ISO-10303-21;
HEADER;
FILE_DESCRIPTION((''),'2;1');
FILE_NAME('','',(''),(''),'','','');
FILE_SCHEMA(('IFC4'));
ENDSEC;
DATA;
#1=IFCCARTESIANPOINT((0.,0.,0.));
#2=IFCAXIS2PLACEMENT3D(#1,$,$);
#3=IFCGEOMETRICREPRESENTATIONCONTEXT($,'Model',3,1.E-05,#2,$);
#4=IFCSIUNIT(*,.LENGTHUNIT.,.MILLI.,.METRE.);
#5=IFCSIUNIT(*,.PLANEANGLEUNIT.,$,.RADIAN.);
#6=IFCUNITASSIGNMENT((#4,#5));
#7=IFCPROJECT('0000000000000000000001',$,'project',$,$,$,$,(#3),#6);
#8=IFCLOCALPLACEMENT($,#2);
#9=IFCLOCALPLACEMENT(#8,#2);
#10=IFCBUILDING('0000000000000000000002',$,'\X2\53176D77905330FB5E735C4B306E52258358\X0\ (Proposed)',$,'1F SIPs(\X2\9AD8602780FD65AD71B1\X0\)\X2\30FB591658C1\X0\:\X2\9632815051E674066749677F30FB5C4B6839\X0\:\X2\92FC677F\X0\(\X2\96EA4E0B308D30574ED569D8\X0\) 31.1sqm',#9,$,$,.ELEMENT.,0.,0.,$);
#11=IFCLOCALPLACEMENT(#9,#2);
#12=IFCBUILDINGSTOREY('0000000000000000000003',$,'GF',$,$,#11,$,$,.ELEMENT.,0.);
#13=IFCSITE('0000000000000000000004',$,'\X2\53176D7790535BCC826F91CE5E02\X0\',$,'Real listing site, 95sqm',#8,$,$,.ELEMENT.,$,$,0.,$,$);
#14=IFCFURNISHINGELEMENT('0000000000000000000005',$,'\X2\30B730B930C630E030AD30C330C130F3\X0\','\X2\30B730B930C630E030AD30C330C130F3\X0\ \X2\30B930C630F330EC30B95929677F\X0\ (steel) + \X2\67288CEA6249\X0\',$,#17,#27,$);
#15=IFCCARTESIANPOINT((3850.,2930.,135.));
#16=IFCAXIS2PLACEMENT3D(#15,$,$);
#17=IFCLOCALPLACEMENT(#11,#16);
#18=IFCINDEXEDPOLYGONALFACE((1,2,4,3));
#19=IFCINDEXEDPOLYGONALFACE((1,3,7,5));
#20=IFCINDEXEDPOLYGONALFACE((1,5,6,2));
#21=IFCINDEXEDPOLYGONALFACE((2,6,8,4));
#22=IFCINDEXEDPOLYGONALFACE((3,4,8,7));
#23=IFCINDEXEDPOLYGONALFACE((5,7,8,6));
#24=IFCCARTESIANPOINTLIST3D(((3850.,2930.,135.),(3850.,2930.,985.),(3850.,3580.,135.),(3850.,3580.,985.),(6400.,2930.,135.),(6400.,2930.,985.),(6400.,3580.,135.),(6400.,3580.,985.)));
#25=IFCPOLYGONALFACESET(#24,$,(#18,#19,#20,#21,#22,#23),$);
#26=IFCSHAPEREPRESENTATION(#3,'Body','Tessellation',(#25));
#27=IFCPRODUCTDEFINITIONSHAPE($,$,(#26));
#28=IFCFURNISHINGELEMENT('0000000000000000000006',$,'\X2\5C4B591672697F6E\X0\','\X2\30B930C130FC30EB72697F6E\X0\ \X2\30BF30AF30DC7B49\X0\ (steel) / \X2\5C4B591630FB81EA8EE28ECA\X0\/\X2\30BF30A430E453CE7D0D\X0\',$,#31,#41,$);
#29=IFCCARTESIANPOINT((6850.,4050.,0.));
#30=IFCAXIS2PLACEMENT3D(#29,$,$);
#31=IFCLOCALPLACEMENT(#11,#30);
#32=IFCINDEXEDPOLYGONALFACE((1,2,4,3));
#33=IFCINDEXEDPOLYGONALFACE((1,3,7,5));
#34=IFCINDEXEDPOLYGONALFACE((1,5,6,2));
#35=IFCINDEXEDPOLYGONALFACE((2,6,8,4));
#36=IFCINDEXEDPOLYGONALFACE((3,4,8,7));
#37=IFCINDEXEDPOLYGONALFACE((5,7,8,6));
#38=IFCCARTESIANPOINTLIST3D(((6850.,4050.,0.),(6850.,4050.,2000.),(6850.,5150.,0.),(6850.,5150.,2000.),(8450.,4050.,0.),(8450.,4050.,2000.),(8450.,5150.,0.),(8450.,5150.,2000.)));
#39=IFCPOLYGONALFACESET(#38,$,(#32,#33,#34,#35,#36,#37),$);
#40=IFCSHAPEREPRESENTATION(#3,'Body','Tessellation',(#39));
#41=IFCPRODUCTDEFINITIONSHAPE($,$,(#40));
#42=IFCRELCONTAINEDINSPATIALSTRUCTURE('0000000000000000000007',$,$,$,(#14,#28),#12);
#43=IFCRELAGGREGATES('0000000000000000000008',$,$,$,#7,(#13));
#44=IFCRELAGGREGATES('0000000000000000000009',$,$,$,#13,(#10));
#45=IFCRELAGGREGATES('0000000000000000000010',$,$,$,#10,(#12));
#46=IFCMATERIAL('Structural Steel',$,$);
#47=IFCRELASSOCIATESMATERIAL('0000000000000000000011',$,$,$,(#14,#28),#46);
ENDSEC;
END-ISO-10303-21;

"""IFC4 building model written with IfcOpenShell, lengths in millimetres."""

from ifc_helpers import new_model, si_unit, frame, frame_2d, origin, place, context, project, spatial, rectangle, extrude, material, element, save


model = new_model("IFC4")

# Units and contexts
model_context = context("Model", 3, precision=1e-05, world=origin())
ifc_project = project(units=[si_unit("LENGTHUNIT", "METRE", prefix="MILLI"), si_unit("PLANEANGLEUNIT", "RADIAN")], contexts=[model_context])

# Site, building, storey
site_placement = place(None, origin())
site = spatial("IfcSite", under=ifc_project, at=site_placement, Name="北海道富良野市", ObjectType="Real listing site, 95sqm", CompositionType="ELEMENT", RefElevation=0.0)
building_placement = place(site_placement, origin())
building = spatial("IfcBuilding", under=site, at=building_placement, Name="北海道・平屋の別荘 (Proposed)", ObjectType="1F SIPs(高性能断熱)・外壁:防腐処理杉板・屋根:鋼板(雪下ろし仕様) 31.1sqm", CompositionType="ELEMENT", ElevationOfRefHeight=0.0, ElevationOfTerrain=0.0)
storey_placement = place(building_placement, origin())
storey = spatial("IfcBuildingStorey", under=building, at=storey_placement, Name="GF", CompositionType="ELEMENT", Elevation=0.0)

# Shared definitions
ifc_material_1 = material(Name="Structural Steel")

# Furnishing elements
furnishing_1_placement = place(storey_placement, frame((3850.0, 2930.0, 135.0)))
element("IfcFurnishingElement", 1, at=furnishing_1_placement, inside=storey, material=ifc_material_1, Name="システムキッチン", Description="システムキッチン ステンレス天板 (steel) + 木質扉", context=model_context, shape_type="SweptSolid", body=[
    extrude(rectangle(XDim=2550.0, YDim=650.0, at=frame_2d((1275.0, 325.0))), frame((3850.0, 2930.0, 135.0)), (0.0, 0.0, 1.0), 850.0),
])
furnishing_2_placement = place(storey_placement, frame((6850.0, 4050.0, 0.0)))
element("IfcFurnishingElement", 2, at=furnishing_2_placement, inside=storey, material=ifc_material_1, Name="屋外物置", Description="スチール物置 タクボ等 (steel) / 屋外・自転車/タイヤ収納", context=model_context, shape_type="SweptSolid", body=[
    extrude(rectangle(XDim=1600.0, YDim=1100.0, at=frame_2d((800.0, 550.0))), frame((6850.0, 4050.0, 0.0)), (0.0, 0.0, 1.0), 2000.0),
])

save(model, "model.ifc")
